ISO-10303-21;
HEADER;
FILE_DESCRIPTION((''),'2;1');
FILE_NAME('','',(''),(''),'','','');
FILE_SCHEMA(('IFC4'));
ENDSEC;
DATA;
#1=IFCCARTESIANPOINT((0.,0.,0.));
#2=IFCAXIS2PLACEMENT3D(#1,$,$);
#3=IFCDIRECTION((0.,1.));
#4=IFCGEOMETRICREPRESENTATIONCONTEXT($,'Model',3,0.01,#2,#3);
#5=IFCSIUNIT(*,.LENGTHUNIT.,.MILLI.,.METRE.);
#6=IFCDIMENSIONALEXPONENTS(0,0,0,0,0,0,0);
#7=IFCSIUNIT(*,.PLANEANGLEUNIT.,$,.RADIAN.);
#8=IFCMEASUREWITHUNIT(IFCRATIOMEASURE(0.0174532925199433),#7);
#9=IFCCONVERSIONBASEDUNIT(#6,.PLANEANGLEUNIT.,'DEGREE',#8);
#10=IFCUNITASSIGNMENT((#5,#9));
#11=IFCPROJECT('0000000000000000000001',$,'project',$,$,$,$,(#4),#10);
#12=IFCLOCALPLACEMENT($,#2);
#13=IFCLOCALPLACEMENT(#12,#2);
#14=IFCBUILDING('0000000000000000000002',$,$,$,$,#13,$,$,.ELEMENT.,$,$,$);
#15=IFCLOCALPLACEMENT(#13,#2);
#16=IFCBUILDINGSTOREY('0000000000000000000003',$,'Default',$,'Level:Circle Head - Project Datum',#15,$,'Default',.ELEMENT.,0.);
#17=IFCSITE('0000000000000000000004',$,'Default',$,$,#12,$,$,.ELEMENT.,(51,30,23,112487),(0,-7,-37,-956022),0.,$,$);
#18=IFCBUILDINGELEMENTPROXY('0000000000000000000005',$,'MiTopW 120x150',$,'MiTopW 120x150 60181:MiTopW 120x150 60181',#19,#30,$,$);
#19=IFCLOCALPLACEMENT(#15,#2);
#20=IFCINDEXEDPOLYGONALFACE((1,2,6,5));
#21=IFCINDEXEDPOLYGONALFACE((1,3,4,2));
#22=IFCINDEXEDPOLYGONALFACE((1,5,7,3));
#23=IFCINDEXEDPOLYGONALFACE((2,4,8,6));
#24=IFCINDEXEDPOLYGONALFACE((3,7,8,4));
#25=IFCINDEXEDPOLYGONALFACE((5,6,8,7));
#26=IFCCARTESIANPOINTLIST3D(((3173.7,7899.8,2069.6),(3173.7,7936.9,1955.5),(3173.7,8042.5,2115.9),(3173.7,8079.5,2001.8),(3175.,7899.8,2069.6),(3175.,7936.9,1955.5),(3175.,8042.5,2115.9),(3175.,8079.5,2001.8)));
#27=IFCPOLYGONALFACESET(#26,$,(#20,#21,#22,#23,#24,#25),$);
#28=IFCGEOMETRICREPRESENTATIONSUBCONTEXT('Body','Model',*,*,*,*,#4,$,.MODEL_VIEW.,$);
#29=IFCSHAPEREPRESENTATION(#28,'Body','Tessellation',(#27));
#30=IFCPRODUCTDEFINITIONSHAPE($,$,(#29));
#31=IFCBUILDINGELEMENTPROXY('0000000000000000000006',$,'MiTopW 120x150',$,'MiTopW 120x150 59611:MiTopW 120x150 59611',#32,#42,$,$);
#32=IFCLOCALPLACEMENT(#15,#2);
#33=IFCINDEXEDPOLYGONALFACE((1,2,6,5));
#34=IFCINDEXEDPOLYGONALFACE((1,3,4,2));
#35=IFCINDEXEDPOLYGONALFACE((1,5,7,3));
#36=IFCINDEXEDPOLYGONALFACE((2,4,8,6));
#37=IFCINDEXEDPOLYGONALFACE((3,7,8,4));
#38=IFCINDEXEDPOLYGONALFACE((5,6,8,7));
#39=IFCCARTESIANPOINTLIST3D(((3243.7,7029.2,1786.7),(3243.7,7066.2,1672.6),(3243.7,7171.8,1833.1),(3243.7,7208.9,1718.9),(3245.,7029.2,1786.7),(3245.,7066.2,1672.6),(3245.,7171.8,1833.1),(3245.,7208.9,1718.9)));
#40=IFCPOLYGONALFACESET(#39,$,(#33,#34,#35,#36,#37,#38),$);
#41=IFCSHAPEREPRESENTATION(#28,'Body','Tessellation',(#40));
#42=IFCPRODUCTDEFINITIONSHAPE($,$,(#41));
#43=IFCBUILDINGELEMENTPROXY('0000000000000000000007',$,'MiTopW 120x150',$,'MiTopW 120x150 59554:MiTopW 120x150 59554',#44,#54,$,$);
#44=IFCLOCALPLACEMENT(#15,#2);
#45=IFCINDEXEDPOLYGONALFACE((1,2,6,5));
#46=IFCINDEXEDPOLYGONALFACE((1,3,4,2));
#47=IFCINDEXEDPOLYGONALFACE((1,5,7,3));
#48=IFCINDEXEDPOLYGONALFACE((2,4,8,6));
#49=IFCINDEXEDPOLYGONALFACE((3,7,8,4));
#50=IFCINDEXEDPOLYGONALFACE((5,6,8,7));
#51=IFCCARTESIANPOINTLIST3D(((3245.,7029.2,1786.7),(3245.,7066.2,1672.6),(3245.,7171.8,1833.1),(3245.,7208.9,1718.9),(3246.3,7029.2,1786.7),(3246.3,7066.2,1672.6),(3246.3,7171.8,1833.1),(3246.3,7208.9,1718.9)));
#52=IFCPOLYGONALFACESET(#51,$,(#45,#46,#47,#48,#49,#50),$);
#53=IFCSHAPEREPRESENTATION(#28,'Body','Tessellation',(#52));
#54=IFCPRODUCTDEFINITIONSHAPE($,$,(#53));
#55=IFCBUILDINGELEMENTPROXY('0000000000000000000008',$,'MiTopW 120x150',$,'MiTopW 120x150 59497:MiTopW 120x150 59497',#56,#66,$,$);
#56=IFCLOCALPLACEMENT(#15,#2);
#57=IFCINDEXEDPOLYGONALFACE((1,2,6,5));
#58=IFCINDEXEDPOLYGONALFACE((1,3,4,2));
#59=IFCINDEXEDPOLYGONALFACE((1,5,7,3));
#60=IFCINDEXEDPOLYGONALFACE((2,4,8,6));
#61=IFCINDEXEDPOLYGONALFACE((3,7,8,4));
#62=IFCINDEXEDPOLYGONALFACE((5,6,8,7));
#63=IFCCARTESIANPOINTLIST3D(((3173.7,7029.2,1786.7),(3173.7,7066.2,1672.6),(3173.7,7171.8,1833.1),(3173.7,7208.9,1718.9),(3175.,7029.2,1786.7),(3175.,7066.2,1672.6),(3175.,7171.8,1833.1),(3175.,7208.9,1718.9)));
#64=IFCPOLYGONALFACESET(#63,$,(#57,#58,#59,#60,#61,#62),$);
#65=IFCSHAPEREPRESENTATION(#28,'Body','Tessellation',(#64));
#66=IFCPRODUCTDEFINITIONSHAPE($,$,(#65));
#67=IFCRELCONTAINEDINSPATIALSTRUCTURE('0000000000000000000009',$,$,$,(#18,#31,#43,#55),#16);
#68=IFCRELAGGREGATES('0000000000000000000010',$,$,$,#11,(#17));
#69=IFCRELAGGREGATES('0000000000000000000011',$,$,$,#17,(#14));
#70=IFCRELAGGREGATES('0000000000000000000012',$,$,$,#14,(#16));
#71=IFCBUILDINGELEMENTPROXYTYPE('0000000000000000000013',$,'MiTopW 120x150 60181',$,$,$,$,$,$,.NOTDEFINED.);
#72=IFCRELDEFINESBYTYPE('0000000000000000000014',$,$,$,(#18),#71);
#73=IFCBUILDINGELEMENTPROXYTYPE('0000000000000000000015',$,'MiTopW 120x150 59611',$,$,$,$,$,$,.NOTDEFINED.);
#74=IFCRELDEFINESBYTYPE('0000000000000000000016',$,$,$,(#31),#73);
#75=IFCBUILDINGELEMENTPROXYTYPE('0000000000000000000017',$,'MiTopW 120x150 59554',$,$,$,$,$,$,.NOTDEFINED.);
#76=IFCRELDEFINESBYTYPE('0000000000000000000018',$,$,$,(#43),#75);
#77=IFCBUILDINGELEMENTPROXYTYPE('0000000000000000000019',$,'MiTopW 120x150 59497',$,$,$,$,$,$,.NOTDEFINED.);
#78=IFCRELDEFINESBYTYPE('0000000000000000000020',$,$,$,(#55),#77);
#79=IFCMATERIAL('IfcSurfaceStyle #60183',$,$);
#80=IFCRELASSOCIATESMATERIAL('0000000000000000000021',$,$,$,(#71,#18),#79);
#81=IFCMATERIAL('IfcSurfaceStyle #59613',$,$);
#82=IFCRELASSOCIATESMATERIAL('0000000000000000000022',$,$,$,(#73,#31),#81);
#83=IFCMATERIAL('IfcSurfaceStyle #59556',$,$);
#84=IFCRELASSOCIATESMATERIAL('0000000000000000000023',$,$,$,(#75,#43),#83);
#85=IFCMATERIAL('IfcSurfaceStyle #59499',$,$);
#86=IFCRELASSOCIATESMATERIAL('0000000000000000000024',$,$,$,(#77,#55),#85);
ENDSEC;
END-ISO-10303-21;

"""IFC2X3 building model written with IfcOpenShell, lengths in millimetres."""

from ifc_helpers import new_model, entity, si_unit, converted_unit, direction, frame, origin, place, context, subcontext, project, spatial, polyline, outline, extrude, source, transform, mapped, material, type_object, type_shapes, element, save


model = new_model("IFC2X3")

# Units and contexts
model_context = context("Model", 3, precision=0.01, world=origin(), true_north=direction((0.0, 1.0)))
body_context = subcontext(model_context, "Body", "Model", "MODEL_VIEW")
ifc_project = project(units=[si_unit("LENGTHUNIT", "METRE", prefix="MILLI"), converted_unit("PLANEANGLEUNIT", "DEGREE", entity("IfcRatioMeasure", 0.0174532925199433), si_unit("PLANEANGLEUNIT", "RADIAN"), dimensions=[0, 0, 0, 0, 0, 0, 0])], contexts=[model_context])

# Site, building, storey
site_placement = place(None, origin())
site = spatial("IfcSite", under=ifc_project, at=site_placement, Name="Default", CompositionType="ELEMENT", RefLatitude=(51, 30, 23, 112487), RefLongitude=(0, -7, -37, -956022), RefElevation=0.0)
building_placement = place(site_placement, origin())
building = spatial("IfcBuilding", under=site, at=building_placement, CompositionType="ELEMENT")
storey_placement = place(building_placement, origin())
storey = spatial("IfcBuildingStorey", under=building, at=storey_placement, Name="Default", ObjectType="Level:Circle Head - Project Datum", LongName="Default", CompositionType="ELEMENT", Elevation=0.0)

# Building element proxies
ifc_material_1 = material(Name="IfcSurfaceStyle #60183")
building_element_proxy_type_1 = type_object("IfcBuildingElementProxyType", Name="MiTopW 120x150 60181", PredefinedType="NOTDEFINED", material=ifc_material_1)
shared_shape_1 = source(origin(), body_context, "Body", "SweptSolid", [
    extrude(outline(polyline([(-75.0, -60.0), (75.0, -60.0), (75.0, 60.0), (-75.0, 60.0), (-75.0, -60.0)])), frame((75.0, 60.0, 0.0), z_axis=(0.0, 0.0, 1.0), x_axis=(-1.0, 0.0, 0.0)), (0.0, 0.0, 1.0), 1.3),
])
type_shapes(building_element_proxy_type_1, [shared_shape_1])
proxy_1_placement = place(building_placement, frame((3175.0, 7899.8, 2069.6), z_axis=(-1.0, 0.0, 0.0), x_axis=(0.0, 0.951057, 0.309017)))
element("IfcBuildingElementProxy", 1, at=proxy_1_placement, inside=storey, type_object=building_element_proxy_type_1, material=ifc_material_1, Name="MiTopW 120x150", ObjectType="MiTopW 120x150 60181:MiTopW 120x150 60181", context=body_context, shape_type="MappedRepresentation", body=[
    mapped(shared_shape_1, transform((0.0, 0.0, 0.0), scale=1.0)),
])
ifc_material_2 = material(Name="IfcSurfaceStyle #59613")
building_element_proxy_type_2 = type_object("IfcBuildingElementProxyType", Name="MiTopW 120x150 59611", PredefinedType="NOTDEFINED", material=ifc_material_2)
shared_shape_2 = source(origin(), body_context, "Body", "SweptSolid", [
    extrude(outline(polyline([(-75.0, -60.0), (75.0, -60.0), (75.0, 60.0), (-75.0, 60.0), (-75.0, -60.0)])), frame((75.0, 60.0, 0.0), z_axis=(0.0, 0.0, 1.0), x_axis=(-1.0, 0.0, 0.0)), (0.0, 0.0, 1.0), 1.3),
])
type_shapes(building_element_proxy_type_2, [shared_shape_2])
proxy_2_placement = place(building_placement, frame((3245.0, 7029.2, 1786.7), z_axis=(-1.0, 0.0, 0.0), x_axis=(0.0, 0.951057, 0.309017)))
element("IfcBuildingElementProxy", 2, at=proxy_2_placement, inside=storey, type_object=building_element_proxy_type_2, material=ifc_material_2, Name="MiTopW 120x150", ObjectType="MiTopW 120x150 59611:MiTopW 120x150 59611", context=body_context, shape_type="MappedRepresentation", body=[
    mapped(shared_shape_2, transform((0.0, 0.0, 0.0), scale=1.0)),
])
ifc_material_3 = material(Name="IfcSurfaceStyle #59556")
building_element_proxy_type_3 = type_object("IfcBuildingElementProxyType", Name="MiTopW 120x150 59554", PredefinedType="NOTDEFINED", material=ifc_material_3)
shared_shape_3 = source(origin(), body_context, "Body", "SweptSolid", [
    extrude(outline(polyline([(-75.0, -60.0), (75.0, -60.0), (75.0, 60.0), (-75.0, 60.0), (-75.0, -60.0)])), frame((75.0, 60.0, 0.0), z_axis=(0.0, 0.0, 1.0), x_axis=(-1.0, 0.0, 0.0)), (0.0, 0.0, 1.0), 1.3),
])
type_shapes(building_element_proxy_type_3, [shared_shape_3])
proxy_3_placement = place(building_placement, frame((3246.3, 7029.2, 1786.7), z_axis=(-1.0, 0.0, 0.0), x_axis=(0.0, 0.951057, 0.309017)))
element("IfcBuildingElementProxy", 3, at=proxy_3_placement, inside=storey, type_object=building_element_proxy_type_3, material=ifc_material_3, Name="MiTopW 120x150", ObjectType="MiTopW 120x150 59554:MiTopW 120x150 59554", context=body_context, shape_type="MappedRepresentation", body=[
    mapped(shared_shape_3, transform((0.0, 0.0, 0.0), scale=1.0)),
])
ifc_material_4 = material(Name="IfcSurfaceStyle #59499")
building_element_proxy_type_4 = type_object("IfcBuildingElementProxyType", Name="MiTopW 120x150 59497", PredefinedType="NOTDEFINED", material=ifc_material_4)
shared_shape_4 = source(origin(), body_context, "Body", "SweptSolid", [
    extrude(outline(polyline([(-75.0, -60.0), (75.0, -60.0), (75.0, 60.0), (-75.0, 60.0), (-75.0, -60.0)])), frame((75.0, 60.0, 0.0), z_axis=(0.0, 0.0, 1.0), x_axis=(-1.0, 0.0, 0.0)), (0.0, 0.0, 1.0), 1.3),
])
type_shapes(building_element_proxy_type_4, [shared_shape_4])
proxy_4_placement = place(building_placement, frame((3175.0, 7029.2, 1786.7), z_axis=(-1.0, 0.0, 0.0), x_axis=(0.0, 0.951057, 0.309017)))
element("IfcBuildingElementProxy", 4, at=proxy_4_placement, inside=storey, type_object=building_element_proxy_type_4, material=ifc_material_4, Name="MiTopW 120x150", ObjectType="MiTopW 120x150 59497:MiTopW 120x150 59497", context=body_context, shape_type="MappedRepresentation", body=[
    mapped(shared_shape_4, transform((0.0, 0.0, 0.0), scale=1.0)),
])

save(model, "model.ifc")
